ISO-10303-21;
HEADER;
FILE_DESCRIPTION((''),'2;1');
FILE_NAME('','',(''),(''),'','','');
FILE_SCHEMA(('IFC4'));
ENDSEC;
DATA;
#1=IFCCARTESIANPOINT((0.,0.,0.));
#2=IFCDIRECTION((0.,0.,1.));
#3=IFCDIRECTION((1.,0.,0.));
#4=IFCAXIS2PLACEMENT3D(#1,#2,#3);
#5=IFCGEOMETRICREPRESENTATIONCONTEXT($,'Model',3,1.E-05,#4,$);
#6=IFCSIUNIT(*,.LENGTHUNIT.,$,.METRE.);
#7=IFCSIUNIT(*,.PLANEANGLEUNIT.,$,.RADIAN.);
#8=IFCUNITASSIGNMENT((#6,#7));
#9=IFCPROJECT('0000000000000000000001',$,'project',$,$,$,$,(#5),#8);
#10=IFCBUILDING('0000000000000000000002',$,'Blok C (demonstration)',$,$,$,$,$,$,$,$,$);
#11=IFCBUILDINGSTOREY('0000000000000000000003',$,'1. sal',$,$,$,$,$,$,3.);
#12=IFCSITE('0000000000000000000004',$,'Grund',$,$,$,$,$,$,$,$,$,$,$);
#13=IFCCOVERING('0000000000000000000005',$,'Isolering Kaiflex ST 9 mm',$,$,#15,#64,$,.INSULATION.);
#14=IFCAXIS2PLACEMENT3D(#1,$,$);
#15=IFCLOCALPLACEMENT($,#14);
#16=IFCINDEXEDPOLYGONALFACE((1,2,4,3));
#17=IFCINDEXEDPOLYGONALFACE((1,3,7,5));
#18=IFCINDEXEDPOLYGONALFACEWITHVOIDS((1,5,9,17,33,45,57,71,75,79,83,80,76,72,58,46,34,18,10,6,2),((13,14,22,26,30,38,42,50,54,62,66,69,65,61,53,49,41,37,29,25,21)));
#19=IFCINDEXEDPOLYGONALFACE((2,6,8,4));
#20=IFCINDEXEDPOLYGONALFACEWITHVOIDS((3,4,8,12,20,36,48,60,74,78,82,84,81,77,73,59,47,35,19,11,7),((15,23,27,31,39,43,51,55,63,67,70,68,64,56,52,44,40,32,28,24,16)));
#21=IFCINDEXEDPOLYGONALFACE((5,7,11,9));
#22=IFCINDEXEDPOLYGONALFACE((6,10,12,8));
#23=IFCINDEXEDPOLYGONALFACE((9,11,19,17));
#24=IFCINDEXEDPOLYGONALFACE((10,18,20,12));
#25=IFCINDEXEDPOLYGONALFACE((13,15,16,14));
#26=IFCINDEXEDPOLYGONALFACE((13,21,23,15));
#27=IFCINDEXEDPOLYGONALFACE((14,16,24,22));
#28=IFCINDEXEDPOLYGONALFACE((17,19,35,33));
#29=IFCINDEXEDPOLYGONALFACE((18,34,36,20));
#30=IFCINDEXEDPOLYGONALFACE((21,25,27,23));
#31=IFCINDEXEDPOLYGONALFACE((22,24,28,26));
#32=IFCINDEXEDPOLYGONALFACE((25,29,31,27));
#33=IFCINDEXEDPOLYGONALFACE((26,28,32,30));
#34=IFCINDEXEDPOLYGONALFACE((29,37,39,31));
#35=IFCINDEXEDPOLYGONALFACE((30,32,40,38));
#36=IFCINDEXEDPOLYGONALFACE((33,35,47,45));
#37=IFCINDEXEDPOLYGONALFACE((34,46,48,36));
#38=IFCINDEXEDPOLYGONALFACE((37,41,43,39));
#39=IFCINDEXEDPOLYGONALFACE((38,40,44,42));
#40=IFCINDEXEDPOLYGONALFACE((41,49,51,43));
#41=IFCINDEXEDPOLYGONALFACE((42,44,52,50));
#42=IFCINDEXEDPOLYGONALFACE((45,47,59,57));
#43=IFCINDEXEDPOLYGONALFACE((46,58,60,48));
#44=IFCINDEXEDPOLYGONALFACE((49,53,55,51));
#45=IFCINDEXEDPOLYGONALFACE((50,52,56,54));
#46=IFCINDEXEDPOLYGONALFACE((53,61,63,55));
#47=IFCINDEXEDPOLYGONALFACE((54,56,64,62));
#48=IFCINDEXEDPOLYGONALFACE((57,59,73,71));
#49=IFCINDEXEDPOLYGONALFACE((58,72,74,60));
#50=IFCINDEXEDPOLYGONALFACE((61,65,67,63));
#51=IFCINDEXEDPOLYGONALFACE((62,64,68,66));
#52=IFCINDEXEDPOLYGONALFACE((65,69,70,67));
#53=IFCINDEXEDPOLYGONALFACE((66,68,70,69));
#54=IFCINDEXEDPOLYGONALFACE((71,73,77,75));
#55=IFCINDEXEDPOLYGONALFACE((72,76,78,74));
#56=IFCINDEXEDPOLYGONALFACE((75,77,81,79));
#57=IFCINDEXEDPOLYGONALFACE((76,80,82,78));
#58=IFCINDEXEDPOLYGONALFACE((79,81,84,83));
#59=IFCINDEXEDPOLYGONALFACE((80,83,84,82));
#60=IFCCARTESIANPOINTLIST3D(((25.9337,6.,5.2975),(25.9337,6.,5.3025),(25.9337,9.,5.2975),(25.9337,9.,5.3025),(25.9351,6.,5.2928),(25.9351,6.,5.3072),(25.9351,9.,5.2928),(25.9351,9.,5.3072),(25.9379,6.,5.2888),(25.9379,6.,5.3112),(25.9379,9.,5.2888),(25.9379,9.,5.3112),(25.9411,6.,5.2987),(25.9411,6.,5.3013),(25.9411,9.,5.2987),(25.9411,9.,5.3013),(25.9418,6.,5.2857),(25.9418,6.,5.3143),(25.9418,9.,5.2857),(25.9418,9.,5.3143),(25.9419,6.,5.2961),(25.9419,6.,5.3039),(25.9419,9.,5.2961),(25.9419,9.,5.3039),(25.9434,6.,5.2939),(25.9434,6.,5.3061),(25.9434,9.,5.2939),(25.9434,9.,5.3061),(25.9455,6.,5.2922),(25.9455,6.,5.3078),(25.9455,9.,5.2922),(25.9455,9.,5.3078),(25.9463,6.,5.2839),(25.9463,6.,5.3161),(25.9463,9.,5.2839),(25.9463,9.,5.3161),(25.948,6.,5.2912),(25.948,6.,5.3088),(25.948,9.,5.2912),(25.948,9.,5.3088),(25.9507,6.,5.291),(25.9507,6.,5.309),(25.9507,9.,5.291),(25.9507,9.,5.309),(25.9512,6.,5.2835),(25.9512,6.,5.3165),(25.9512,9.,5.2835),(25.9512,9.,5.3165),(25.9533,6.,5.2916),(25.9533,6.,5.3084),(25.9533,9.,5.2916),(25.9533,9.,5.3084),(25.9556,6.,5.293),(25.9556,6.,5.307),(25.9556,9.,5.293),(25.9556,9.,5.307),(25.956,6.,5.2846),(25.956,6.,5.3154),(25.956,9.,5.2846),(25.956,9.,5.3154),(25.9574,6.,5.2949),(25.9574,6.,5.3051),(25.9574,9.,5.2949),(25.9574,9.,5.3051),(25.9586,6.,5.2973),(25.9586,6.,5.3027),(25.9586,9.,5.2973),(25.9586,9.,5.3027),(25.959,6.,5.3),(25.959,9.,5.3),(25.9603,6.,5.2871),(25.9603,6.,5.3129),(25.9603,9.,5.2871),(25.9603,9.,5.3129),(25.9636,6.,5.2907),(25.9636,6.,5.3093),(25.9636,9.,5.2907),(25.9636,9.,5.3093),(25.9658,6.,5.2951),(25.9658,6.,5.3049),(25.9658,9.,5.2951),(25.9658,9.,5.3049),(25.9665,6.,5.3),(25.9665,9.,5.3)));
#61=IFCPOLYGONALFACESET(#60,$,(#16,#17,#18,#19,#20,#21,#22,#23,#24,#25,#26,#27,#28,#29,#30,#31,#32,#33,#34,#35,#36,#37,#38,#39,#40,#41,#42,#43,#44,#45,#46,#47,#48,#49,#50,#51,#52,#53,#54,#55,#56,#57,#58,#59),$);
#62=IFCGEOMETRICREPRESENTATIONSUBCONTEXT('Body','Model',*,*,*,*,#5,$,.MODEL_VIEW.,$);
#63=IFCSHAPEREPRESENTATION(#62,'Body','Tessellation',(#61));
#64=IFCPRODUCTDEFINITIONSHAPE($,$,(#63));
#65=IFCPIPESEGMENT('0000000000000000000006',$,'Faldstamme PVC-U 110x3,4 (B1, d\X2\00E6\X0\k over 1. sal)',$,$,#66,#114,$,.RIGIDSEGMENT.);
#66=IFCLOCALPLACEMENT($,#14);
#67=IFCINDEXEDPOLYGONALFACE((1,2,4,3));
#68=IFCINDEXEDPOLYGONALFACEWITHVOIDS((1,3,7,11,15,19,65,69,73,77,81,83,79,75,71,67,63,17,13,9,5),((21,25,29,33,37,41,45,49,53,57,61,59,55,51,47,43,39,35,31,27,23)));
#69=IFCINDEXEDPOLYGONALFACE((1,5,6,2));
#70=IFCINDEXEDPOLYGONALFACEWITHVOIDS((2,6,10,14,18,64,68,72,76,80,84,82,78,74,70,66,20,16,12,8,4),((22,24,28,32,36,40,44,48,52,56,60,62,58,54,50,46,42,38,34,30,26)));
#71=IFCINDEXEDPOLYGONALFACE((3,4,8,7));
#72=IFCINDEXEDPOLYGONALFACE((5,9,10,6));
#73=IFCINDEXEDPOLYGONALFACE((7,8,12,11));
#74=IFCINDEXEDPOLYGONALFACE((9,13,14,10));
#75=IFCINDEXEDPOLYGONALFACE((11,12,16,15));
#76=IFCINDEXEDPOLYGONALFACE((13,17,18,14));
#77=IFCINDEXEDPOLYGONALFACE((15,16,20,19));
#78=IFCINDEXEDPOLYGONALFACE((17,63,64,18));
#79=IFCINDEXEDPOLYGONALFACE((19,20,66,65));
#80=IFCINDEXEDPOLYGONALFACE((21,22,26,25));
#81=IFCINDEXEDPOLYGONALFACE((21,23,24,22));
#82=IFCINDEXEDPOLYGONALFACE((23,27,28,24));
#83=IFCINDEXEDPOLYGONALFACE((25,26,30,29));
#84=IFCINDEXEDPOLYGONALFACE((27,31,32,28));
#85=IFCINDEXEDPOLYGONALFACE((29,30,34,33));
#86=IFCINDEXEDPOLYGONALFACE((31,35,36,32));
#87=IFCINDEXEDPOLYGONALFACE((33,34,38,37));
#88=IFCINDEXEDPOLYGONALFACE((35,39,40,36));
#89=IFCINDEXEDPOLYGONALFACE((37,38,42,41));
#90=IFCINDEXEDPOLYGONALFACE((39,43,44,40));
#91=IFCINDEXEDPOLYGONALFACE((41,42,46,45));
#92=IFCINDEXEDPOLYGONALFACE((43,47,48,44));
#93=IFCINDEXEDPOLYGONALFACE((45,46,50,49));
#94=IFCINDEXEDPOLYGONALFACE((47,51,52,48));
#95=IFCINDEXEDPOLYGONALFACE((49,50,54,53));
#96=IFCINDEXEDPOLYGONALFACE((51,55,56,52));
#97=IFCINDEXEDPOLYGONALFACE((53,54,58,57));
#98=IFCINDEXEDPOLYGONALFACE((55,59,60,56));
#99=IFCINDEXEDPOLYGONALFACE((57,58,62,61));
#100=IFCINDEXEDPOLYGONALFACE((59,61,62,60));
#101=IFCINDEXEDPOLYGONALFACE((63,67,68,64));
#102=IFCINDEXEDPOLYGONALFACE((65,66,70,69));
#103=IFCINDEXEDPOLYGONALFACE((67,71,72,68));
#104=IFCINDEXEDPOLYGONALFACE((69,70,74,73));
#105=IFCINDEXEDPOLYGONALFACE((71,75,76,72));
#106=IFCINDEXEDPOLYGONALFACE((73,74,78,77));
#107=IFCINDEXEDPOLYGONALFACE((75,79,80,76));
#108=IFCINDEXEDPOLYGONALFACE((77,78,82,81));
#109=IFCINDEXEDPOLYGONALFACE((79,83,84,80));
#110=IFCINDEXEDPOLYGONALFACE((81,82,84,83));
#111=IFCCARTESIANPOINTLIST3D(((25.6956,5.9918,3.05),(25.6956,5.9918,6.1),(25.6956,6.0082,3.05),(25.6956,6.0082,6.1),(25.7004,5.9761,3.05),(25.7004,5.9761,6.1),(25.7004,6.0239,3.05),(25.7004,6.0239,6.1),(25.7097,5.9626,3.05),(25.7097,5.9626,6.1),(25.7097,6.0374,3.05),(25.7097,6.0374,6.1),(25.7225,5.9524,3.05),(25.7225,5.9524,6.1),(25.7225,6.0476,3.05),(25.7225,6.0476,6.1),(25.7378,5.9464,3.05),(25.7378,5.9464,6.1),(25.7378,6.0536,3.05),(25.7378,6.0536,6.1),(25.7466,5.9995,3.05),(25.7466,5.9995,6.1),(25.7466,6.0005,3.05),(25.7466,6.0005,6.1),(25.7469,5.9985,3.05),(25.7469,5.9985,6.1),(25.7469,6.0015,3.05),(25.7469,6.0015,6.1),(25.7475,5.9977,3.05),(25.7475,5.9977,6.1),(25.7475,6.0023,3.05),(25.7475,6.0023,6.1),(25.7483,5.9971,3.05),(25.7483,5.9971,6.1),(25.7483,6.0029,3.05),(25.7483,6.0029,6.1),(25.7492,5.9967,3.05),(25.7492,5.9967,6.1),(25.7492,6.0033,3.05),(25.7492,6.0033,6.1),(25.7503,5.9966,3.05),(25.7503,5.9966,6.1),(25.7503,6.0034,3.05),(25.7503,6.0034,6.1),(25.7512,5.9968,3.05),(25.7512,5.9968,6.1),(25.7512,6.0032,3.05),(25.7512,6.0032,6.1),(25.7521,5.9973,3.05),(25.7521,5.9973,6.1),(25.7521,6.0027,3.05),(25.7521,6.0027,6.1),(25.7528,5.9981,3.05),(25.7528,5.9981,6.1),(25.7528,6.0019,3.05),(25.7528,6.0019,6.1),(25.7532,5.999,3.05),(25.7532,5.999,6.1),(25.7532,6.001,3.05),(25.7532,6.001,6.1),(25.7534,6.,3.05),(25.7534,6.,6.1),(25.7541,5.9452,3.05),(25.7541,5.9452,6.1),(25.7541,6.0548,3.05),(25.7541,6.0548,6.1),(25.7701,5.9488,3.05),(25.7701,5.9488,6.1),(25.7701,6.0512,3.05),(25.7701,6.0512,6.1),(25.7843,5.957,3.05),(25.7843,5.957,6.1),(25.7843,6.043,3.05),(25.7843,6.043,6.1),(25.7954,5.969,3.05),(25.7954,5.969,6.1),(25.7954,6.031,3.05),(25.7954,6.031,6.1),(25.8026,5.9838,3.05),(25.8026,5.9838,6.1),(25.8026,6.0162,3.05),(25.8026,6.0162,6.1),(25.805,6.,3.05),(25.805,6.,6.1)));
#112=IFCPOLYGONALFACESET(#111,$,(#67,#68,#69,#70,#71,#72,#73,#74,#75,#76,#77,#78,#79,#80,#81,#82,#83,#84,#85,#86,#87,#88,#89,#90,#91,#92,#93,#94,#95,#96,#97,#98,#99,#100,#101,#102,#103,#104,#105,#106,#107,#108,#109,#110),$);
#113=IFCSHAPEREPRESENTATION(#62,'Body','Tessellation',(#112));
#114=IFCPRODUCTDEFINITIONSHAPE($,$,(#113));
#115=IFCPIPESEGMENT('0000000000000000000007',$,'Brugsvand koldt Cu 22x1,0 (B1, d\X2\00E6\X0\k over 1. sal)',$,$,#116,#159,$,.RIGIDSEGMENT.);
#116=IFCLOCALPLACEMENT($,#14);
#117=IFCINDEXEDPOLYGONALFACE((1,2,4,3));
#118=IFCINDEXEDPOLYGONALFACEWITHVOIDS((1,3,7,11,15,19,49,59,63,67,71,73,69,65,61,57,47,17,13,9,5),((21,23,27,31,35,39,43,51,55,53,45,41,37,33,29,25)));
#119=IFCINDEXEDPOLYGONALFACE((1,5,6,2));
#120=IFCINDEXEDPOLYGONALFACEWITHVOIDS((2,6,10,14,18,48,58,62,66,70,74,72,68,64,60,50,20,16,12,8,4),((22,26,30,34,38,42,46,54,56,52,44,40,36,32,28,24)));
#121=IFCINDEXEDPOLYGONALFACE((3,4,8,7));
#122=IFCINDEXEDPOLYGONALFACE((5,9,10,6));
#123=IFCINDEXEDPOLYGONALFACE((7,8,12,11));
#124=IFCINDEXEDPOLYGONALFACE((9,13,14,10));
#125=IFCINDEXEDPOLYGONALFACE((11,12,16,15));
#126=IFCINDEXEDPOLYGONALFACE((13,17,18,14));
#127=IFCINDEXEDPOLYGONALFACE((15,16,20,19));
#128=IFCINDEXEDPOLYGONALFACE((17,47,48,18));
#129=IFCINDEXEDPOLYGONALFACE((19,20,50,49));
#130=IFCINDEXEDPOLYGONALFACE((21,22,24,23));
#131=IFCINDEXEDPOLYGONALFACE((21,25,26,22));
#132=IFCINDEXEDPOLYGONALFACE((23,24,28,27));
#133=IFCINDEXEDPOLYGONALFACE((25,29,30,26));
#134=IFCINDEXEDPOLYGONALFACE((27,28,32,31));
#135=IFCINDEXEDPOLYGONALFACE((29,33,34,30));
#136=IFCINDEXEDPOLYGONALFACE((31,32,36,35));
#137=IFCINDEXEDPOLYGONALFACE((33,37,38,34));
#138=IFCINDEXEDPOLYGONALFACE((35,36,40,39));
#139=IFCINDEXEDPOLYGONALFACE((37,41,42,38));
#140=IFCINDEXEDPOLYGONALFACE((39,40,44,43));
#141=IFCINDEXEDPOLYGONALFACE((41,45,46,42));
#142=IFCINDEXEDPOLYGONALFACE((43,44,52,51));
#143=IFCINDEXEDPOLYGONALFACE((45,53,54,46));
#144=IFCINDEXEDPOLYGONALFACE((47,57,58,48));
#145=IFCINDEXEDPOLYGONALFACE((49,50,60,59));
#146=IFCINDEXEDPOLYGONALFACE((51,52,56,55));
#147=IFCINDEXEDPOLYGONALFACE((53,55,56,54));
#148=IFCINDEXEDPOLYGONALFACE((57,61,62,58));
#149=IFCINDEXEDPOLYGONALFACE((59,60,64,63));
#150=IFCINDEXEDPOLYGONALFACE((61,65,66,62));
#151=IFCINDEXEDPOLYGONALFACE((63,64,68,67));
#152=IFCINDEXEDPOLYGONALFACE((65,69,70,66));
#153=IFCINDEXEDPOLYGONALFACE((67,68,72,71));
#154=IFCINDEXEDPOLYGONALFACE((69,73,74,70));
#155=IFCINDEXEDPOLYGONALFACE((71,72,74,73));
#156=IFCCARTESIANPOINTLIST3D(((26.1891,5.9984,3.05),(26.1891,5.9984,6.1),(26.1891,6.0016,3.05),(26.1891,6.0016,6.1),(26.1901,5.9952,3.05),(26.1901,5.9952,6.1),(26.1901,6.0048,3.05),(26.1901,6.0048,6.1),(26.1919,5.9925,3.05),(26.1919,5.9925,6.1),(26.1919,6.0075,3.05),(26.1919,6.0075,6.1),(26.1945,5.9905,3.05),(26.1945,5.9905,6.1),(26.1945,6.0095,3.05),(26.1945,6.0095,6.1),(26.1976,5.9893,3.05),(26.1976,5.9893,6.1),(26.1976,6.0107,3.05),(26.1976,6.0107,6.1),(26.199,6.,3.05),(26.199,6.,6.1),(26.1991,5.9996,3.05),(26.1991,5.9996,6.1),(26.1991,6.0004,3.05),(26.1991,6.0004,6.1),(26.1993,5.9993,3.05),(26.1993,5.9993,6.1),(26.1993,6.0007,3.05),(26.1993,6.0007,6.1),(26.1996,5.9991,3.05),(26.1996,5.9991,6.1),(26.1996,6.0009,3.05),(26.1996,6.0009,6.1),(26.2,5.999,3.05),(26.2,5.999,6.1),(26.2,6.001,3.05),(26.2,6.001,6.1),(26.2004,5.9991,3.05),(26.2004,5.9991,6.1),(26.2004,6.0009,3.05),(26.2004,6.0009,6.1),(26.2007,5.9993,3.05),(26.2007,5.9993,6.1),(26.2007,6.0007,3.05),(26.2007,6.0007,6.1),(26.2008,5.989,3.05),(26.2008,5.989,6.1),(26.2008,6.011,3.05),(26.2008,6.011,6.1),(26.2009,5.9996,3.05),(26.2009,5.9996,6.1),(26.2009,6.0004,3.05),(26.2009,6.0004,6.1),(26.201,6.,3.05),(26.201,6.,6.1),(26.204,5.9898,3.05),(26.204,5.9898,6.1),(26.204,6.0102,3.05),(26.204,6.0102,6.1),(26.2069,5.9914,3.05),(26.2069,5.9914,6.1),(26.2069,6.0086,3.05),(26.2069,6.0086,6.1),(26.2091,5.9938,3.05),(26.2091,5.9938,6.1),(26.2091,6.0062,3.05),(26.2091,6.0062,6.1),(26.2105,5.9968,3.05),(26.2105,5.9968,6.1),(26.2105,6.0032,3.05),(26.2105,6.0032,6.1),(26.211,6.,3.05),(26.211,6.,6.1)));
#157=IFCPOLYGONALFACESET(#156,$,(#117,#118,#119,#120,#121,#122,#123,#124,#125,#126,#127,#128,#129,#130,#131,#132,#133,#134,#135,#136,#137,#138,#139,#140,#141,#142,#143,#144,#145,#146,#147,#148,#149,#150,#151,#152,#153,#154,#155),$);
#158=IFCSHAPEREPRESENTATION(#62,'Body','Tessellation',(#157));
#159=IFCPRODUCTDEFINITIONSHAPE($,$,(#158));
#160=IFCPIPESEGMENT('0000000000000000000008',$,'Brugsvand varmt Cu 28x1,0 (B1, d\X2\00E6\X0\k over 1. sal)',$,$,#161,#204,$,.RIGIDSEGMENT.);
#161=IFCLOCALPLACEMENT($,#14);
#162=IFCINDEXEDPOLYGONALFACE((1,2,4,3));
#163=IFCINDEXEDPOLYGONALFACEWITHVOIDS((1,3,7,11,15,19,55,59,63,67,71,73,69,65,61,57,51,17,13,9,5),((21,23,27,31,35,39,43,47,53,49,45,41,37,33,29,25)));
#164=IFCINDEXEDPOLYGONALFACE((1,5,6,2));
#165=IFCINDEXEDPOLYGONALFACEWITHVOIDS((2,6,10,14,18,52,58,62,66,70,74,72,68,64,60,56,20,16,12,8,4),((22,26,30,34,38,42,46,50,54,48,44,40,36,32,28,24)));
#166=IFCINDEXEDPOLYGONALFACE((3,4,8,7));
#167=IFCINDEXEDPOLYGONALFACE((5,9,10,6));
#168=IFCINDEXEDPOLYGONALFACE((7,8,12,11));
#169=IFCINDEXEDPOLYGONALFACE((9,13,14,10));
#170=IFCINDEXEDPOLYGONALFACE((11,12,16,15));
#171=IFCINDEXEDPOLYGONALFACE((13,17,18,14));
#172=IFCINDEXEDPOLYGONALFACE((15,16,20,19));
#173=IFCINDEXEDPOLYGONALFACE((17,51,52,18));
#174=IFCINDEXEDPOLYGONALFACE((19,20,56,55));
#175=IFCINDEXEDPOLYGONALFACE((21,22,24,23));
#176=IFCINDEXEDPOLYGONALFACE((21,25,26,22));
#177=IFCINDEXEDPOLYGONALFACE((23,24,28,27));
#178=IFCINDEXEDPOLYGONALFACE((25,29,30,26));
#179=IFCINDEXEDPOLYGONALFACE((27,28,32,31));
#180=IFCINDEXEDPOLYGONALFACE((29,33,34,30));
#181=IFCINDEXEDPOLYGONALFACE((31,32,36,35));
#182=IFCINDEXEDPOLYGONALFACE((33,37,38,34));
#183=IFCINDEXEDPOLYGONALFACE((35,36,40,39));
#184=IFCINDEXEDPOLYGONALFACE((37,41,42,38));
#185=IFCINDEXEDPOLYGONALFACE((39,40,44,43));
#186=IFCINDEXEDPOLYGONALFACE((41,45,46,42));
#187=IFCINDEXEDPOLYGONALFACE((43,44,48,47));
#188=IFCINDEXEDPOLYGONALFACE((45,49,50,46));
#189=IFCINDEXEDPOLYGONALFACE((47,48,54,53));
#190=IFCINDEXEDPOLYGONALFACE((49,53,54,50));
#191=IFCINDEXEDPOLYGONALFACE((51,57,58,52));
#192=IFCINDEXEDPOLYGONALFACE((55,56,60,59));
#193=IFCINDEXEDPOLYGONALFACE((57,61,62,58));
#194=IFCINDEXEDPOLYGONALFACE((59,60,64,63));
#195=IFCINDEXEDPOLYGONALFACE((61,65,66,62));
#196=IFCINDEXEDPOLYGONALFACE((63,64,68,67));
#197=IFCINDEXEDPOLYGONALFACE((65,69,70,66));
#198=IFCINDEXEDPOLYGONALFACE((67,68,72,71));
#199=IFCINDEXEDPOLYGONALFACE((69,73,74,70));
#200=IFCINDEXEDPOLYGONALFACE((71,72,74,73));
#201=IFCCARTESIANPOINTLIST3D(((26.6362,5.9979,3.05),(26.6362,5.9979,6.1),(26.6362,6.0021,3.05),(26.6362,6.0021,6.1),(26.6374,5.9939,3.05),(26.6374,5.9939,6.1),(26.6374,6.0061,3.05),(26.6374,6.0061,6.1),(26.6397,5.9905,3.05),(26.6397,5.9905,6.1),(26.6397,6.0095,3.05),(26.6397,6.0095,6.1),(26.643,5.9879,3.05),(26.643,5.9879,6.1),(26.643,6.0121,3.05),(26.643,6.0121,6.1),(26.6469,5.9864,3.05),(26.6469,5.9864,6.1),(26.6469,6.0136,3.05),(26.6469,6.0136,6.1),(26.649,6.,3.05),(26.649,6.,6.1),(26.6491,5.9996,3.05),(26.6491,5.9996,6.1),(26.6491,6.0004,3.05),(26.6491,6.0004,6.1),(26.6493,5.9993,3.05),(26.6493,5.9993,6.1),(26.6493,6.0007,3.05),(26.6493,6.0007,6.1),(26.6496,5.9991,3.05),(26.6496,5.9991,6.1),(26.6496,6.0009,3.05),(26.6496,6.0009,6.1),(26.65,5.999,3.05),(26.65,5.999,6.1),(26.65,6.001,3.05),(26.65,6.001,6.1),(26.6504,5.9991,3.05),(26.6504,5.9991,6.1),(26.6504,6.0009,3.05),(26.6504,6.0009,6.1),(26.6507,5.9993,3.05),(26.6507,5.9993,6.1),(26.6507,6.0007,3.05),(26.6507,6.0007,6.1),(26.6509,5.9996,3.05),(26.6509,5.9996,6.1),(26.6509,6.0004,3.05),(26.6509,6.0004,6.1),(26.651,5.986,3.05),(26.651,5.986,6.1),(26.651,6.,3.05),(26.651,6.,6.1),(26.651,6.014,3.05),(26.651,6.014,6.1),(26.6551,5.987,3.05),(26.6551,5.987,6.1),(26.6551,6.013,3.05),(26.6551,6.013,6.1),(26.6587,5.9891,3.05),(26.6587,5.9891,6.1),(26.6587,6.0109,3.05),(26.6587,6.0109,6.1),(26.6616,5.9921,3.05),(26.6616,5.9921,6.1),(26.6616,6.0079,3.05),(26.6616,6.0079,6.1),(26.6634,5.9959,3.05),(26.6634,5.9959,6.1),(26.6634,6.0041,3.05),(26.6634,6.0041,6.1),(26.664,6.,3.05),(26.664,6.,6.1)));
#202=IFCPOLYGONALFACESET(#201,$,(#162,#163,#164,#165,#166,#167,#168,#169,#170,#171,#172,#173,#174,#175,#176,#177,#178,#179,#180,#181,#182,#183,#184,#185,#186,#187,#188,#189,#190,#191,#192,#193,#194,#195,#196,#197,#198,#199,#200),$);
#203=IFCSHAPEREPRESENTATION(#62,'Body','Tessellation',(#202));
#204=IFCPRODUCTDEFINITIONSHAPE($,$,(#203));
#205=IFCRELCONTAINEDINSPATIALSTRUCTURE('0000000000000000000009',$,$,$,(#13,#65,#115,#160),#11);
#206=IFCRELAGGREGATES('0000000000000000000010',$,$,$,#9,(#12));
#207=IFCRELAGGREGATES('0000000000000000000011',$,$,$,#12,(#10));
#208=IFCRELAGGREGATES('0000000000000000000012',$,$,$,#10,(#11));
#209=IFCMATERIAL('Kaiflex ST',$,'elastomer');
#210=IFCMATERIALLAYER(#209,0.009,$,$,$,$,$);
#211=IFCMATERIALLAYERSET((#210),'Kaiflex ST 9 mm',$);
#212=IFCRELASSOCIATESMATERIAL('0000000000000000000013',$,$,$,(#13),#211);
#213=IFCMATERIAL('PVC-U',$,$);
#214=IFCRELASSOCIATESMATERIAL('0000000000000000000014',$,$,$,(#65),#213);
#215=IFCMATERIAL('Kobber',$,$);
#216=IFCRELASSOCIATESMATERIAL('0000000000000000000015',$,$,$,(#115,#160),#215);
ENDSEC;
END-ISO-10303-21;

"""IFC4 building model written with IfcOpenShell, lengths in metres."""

from ifc_helpers import new_model, si_unit, frame, origin_with_axes, place, context, subcontext, project, spatial, hollow_circle, extrude, material, layer, layer_set, element, save


model = new_model("IFC4")

# Units and contexts
model_context = context("Model", 3, precision=1e-05, world=origin_with_axes())
body_context = subcontext(model_context, "Body", "Model", "MODEL_VIEW")
ifc_project = project(units=[si_unit("LENGTHUNIT", "METRE"), si_unit("PLANEANGLEUNIT", "RADIAN")], contexts=[model_context])

# Site, building, storey
site = spatial("IfcSite", under=ifc_project, Name="Grund")
building = spatial("IfcBuilding", under=site, Name="Blok C (demonstration)")
storey = spatial("IfcBuildingStorey", under=building, Name="1. sal", Elevation=3.0)

# Covering
ifc_material_1 = material(Name="Kaiflex ST", Category="elastomer")
ifc_layer_1 = layer(ifc_material_1, 0.009)
ifc_layer_set_1 = layer_set([ifc_layer_1], Name="Kaiflex ST 9 mm")
covering_1_placement = place(None, origin_with_axes())
element("IfcCovering", 1, at=covering_1_placement, inside=storey, material=ifc_layer_set_1, Name="Isolering Kaiflex ST 9 mm", PredefinedType="INSULATION", context=body_context, shape_type="SweptSolid", body=[
    extrude(hollow_circle(Radius=0.0165, WallThickness=0.0075), frame((25.95, 6.0, 5.3), z_axis=(0.0, 1.0, 0.0), x_axis=(1.0, 0.0, 0.0)), (0.0, 0.0, 1.0), 3.0),
])

# Pipe segments
ifc_material_2 = material(Name="PVC-U")
pipe_segment_1_placement = place(None, origin_with_axes())
element("IfcPipeSegment", 2, at=pipe_segment_1_placement, inside=storey, material=ifc_material_2, Name="Faldstamme PVC-U 110x3,4 (B1, dæk over 1. sal)", PredefinedType="RIGIDSEGMENT", context=body_context, shape_type="SweptSolid", body=[
    extrude(hollow_circle(Radius=0.055, WallThickness=0.0516), frame((25.75, 6.0, 3.05), z_axis=(0.0, 0.0, 1.0), x_axis=(1.0, 0.0, 0.0)), (0.0, 0.0, 1.0), 3.05),
])
ifc_material_3 = material(Name="Kobber")
pipe_segment_2_placement = place(None, origin_with_axes())
element("IfcPipeSegment", 3, at=pipe_segment_2_placement, inside=storey, material=ifc_material_3, Name="Brugsvand koldt Cu 22x1,0 (B1, dæk over 1. sal)", PredefinedType="RIGIDSEGMENT", context=body_context, shape_type="SweptSolid", body=[
    extrude(hollow_circle(Radius=0.011, WallThickness=0.01), frame((26.2, 6.0, 3.05), z_axis=(0.0, 0.0, 1.0), x_axis=(1.0, 0.0, 0.0)), (0.0, 0.0, 1.0), 3.05),
])
pipe_segment_3_placement = place(None, origin_with_axes())
element("IfcPipeSegment", 4, at=pipe_segment_3_placement, inside=storey, material=ifc_material_3, Name="Brugsvand varmt Cu 28x1,0 (B1, dæk over 1. sal)", PredefinedType="RIGIDSEGMENT", context=body_context, shape_type="SweptSolid", body=[
    extrude(hollow_circle(Radius=0.014, WallThickness=0.013), frame((26.65, 6.0, 3.05), z_axis=(0.0, 0.0, 1.0), x_axis=(1.0, 0.0, 0.0)), (0.0, 0.0, 1.0), 3.05),
])

save(model, "model.ifc")
